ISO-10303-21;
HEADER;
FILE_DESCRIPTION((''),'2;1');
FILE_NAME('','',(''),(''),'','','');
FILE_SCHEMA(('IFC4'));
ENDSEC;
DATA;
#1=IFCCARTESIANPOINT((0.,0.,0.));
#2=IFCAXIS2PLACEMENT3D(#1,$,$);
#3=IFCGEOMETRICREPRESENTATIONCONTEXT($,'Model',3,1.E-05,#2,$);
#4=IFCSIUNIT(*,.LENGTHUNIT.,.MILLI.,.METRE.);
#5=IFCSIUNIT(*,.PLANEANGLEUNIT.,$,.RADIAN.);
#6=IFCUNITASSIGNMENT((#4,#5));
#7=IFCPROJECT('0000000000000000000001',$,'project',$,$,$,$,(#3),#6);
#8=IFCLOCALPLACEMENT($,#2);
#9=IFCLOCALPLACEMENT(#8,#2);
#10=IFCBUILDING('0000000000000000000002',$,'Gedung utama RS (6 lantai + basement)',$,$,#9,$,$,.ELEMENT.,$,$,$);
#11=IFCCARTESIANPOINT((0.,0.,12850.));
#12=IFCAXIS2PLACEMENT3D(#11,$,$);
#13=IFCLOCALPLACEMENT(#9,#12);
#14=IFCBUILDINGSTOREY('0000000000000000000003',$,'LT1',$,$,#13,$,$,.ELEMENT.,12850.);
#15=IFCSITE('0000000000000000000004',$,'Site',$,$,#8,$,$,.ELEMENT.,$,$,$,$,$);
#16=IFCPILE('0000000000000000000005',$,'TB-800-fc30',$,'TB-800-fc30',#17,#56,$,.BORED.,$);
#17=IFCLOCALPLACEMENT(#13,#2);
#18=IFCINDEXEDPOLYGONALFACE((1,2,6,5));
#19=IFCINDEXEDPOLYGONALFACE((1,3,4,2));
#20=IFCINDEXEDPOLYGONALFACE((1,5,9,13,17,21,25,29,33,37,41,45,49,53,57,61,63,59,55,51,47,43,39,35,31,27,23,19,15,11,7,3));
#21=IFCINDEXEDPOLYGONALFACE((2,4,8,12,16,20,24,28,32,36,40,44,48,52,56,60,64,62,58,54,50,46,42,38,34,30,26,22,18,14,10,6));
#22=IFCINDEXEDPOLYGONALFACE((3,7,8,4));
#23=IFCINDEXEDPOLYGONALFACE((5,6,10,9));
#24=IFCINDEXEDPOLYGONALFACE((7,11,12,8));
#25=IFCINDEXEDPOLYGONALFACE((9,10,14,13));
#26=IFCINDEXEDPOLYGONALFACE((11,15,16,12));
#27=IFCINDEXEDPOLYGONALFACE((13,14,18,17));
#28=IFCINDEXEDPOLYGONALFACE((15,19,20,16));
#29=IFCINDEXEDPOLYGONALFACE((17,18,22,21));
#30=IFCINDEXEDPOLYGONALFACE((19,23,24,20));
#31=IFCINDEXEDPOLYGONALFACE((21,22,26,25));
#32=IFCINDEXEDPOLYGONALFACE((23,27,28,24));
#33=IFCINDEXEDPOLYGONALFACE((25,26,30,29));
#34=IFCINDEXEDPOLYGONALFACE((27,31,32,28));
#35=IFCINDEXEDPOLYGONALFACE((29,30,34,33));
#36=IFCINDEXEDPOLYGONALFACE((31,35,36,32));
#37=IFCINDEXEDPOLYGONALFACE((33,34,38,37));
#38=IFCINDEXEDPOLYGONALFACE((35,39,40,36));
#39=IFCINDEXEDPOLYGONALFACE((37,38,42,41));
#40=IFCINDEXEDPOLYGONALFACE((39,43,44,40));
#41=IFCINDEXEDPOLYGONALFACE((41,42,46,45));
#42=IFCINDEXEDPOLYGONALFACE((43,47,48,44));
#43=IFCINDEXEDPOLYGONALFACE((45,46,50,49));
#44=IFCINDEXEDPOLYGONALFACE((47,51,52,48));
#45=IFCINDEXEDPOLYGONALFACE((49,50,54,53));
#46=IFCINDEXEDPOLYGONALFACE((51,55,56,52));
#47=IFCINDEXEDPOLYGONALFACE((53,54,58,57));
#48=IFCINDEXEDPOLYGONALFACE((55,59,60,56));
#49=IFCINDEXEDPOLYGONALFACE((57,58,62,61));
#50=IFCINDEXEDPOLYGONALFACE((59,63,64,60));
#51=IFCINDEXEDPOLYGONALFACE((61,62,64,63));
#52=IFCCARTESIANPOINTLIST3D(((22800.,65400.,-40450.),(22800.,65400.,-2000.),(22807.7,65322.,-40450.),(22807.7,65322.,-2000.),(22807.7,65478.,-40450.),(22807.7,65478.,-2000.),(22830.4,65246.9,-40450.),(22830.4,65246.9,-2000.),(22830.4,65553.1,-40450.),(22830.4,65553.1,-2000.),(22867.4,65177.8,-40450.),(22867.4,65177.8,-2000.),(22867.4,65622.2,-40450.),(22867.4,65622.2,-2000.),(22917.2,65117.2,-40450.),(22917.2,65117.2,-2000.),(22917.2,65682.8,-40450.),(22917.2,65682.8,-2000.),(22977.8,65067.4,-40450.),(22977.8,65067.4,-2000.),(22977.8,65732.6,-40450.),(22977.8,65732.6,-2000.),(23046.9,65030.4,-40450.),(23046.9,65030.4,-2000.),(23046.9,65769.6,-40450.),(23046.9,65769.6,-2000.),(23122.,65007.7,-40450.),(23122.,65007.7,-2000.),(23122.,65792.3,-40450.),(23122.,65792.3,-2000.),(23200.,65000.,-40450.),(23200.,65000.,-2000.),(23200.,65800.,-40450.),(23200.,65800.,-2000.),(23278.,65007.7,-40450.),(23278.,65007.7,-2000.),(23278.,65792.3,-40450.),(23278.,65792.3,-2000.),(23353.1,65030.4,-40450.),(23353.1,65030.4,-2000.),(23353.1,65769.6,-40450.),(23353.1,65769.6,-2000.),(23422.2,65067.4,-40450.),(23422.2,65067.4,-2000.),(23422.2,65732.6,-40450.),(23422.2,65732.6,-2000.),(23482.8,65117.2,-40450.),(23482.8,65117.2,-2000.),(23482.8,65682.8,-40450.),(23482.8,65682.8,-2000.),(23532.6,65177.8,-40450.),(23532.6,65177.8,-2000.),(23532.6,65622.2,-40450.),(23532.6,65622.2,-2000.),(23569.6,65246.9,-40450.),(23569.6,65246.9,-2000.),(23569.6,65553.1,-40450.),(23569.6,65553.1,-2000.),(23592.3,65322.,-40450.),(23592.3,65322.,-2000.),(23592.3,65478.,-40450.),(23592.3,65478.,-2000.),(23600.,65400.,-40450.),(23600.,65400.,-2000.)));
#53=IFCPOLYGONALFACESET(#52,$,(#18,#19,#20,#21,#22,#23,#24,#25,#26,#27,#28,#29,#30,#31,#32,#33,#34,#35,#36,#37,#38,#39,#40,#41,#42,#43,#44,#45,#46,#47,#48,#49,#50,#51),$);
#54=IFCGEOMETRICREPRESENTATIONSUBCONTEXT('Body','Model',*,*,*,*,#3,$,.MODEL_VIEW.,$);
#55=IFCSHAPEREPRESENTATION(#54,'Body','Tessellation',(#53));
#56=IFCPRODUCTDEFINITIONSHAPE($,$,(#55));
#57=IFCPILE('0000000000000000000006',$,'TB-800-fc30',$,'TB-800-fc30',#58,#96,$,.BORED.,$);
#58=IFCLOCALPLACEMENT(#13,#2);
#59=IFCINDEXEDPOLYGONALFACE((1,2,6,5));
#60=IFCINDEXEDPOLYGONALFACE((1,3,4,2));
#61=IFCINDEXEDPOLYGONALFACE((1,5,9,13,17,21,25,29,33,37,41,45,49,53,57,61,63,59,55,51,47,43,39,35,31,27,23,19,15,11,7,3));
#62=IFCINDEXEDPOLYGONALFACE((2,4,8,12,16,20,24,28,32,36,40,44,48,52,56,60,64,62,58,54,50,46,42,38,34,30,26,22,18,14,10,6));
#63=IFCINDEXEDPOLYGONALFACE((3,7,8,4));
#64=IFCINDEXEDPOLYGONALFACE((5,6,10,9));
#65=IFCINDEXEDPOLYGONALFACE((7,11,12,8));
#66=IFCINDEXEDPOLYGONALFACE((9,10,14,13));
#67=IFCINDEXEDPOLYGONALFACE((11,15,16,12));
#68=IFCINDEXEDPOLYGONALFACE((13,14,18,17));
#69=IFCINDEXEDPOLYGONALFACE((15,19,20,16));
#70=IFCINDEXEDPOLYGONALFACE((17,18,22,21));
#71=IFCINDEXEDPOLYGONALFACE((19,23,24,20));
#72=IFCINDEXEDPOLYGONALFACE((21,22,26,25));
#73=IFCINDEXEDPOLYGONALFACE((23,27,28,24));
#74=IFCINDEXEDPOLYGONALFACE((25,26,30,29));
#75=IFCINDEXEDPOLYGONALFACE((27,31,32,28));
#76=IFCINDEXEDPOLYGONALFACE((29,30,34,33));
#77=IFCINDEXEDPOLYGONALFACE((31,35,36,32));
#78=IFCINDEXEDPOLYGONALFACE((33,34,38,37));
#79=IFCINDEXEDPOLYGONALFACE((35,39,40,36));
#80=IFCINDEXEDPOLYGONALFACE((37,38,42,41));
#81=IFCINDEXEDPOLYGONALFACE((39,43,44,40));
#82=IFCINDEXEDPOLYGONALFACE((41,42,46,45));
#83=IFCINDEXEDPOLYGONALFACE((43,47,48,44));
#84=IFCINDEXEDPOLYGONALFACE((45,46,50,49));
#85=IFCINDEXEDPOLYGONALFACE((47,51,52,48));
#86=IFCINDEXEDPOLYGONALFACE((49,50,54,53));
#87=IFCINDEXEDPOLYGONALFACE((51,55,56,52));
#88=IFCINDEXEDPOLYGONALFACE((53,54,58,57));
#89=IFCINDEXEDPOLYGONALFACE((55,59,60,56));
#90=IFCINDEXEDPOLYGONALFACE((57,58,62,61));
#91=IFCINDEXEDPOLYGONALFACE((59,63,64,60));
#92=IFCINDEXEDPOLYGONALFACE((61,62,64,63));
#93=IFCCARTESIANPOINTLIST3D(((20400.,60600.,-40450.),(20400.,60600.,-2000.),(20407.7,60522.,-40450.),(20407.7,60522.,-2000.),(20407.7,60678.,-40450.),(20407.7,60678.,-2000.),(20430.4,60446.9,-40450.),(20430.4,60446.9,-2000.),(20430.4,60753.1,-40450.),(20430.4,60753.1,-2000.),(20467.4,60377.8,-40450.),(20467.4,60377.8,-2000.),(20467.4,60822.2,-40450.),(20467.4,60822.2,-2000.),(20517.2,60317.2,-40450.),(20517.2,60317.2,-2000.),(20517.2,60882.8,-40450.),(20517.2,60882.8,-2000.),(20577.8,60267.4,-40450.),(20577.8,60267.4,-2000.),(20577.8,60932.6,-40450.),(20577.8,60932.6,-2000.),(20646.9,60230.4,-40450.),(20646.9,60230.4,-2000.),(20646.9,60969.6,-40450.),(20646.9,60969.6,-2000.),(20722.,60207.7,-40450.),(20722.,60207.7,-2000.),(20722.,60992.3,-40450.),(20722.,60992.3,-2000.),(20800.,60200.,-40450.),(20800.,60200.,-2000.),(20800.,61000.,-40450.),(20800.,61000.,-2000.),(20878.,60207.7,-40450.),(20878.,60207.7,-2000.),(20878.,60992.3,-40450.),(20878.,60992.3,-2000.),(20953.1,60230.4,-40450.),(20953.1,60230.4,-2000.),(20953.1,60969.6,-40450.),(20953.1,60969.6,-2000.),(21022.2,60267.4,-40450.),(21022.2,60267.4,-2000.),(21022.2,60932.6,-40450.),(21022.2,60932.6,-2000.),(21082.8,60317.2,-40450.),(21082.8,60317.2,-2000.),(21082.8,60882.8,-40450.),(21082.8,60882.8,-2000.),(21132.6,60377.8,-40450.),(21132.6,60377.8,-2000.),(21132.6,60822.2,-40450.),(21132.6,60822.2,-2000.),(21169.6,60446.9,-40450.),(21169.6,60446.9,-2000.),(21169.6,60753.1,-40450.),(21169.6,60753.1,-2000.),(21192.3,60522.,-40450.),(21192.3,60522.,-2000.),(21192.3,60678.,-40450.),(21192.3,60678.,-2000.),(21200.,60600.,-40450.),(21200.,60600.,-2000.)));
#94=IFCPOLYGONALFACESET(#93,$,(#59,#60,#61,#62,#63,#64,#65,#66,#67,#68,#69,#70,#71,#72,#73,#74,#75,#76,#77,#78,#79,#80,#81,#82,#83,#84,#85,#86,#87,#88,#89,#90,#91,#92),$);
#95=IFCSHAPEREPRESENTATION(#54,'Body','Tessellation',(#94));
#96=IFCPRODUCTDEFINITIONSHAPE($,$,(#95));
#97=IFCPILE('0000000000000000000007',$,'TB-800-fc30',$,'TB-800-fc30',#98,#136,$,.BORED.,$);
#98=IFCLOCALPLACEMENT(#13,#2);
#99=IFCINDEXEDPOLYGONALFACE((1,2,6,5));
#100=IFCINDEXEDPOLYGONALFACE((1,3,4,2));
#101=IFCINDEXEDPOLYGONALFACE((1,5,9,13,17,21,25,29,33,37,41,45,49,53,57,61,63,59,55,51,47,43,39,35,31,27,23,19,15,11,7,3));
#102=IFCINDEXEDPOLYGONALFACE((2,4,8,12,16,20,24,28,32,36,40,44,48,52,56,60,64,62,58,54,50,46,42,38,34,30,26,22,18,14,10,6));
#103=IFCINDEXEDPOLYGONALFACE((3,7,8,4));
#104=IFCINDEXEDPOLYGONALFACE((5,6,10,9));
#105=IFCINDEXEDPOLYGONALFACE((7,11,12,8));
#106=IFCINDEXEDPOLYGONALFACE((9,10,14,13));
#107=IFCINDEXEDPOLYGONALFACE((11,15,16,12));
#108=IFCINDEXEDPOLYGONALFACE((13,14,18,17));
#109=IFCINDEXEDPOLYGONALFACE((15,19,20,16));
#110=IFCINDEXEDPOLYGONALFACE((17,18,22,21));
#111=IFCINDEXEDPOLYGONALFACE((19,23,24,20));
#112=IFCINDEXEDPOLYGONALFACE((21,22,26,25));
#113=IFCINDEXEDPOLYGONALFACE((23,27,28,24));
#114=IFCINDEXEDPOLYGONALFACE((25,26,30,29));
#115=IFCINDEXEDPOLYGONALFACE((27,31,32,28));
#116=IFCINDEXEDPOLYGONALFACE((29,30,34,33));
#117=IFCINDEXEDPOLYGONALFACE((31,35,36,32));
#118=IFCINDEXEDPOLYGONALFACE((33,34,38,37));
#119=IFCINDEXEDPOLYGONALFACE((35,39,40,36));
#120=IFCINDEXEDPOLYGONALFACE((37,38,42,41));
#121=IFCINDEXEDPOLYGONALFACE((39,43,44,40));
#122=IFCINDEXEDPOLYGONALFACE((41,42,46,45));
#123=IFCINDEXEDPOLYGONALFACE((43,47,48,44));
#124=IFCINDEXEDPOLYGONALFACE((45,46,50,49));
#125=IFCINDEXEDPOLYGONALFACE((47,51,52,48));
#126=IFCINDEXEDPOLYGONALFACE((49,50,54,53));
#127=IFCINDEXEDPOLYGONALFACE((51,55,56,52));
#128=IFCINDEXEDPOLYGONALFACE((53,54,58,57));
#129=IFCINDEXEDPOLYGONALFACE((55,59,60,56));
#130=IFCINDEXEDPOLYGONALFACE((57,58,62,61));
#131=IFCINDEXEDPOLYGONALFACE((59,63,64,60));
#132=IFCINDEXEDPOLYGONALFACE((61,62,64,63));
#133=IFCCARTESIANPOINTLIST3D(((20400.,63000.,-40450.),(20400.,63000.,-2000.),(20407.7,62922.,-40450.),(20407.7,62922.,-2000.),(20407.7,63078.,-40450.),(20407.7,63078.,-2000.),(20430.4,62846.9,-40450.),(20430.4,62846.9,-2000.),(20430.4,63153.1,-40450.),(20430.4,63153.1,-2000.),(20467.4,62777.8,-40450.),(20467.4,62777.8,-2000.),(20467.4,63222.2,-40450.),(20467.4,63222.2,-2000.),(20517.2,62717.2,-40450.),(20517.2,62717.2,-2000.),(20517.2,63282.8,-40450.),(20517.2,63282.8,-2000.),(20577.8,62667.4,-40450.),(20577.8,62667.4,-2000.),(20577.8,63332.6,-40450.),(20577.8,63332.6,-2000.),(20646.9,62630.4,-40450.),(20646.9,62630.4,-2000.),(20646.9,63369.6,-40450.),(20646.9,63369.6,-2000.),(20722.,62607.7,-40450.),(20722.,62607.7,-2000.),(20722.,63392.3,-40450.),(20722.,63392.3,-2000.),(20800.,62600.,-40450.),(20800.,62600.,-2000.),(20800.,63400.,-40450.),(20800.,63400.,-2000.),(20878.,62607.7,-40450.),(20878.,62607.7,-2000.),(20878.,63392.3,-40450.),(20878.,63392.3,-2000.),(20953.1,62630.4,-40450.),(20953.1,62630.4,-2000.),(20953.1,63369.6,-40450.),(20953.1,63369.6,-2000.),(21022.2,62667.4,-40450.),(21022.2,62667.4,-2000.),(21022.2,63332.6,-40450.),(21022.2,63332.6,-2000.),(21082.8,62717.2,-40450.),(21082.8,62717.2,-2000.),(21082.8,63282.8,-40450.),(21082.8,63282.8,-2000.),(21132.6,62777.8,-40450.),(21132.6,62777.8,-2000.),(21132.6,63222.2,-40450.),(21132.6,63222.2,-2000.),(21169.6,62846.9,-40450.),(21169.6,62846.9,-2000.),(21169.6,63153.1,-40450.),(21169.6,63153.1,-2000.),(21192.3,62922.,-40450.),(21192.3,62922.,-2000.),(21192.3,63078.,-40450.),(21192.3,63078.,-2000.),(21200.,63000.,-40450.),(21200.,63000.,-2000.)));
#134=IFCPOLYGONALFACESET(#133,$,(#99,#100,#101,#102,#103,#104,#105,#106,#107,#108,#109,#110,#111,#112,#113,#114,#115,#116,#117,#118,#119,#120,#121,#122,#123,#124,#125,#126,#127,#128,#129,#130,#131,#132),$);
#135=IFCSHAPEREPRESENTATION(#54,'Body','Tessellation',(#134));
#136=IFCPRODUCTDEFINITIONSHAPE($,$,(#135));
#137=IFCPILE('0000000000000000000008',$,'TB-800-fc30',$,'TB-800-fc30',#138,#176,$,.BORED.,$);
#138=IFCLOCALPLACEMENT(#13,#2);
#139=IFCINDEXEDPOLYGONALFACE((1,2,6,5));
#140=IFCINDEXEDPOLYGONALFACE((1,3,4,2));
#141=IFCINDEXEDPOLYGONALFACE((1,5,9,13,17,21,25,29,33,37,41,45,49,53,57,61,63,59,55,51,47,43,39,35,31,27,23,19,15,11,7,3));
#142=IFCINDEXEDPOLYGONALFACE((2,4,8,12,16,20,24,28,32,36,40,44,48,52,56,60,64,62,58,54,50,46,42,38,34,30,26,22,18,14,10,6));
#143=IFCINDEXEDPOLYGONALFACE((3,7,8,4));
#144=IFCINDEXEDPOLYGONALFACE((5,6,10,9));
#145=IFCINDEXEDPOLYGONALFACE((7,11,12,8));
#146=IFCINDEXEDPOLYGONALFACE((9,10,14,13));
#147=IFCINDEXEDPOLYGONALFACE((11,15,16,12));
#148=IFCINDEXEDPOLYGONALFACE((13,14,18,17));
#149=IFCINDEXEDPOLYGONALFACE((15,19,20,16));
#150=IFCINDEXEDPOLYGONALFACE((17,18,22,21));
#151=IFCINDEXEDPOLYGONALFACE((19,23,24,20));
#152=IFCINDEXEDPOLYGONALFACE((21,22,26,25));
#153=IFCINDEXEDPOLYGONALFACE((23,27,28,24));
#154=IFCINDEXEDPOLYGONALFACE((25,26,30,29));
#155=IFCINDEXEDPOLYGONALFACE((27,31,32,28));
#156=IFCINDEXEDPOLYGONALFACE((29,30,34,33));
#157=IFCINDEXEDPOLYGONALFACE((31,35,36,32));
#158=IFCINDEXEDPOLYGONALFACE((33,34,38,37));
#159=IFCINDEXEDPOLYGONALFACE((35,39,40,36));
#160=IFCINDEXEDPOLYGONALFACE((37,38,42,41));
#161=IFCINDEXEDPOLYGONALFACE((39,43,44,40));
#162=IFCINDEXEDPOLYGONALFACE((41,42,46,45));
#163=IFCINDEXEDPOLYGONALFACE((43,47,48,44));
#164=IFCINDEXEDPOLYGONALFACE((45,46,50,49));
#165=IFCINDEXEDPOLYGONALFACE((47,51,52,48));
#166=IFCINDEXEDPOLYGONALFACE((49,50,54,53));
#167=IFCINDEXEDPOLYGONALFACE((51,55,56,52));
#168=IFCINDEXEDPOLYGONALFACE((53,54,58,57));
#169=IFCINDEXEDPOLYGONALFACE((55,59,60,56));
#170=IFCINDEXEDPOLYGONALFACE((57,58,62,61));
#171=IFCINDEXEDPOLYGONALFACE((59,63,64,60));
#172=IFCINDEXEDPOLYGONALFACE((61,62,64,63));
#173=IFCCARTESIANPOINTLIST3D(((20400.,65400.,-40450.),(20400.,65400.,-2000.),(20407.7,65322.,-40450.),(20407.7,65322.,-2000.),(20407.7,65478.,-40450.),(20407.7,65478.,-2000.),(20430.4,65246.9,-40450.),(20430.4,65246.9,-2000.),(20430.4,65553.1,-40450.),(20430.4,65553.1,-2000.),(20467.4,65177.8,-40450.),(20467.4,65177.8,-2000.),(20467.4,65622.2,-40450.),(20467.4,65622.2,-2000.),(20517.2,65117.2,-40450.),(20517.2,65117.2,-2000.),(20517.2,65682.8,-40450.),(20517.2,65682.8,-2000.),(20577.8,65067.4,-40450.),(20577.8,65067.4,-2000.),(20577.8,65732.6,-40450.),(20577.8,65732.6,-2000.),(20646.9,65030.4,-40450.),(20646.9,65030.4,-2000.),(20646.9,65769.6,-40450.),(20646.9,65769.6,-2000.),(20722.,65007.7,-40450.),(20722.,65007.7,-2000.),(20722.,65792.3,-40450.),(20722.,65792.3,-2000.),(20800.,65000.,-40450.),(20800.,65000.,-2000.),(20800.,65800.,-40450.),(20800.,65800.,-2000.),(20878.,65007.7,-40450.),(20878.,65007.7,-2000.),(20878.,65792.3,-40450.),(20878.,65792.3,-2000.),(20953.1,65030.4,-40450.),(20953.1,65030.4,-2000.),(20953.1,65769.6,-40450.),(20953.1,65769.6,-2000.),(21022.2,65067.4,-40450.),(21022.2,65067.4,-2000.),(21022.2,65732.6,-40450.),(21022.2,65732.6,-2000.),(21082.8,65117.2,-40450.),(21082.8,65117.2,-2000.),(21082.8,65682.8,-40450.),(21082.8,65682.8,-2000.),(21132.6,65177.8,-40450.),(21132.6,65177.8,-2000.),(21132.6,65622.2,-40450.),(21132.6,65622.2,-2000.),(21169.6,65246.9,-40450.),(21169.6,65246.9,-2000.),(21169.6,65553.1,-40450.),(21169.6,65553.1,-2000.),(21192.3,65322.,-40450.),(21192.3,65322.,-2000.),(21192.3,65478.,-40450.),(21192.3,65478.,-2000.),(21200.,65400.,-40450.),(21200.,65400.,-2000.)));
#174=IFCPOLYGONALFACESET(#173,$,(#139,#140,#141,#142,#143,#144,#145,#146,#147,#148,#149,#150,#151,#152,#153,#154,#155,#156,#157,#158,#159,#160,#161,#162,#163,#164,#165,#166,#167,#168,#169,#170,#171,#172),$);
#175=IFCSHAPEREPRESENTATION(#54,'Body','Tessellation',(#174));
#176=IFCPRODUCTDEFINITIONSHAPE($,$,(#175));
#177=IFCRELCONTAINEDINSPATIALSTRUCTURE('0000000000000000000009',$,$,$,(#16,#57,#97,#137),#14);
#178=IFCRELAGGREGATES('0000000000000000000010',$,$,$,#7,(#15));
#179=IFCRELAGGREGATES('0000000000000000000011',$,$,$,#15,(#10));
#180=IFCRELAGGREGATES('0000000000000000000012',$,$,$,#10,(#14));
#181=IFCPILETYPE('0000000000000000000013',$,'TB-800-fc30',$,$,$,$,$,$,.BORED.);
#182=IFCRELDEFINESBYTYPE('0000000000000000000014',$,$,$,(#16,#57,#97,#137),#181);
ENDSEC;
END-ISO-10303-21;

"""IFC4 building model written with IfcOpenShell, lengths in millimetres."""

from ifc_helpers import new_model, si_unit, frame, origin, origin_2d, place, context, subcontext, project, spatial, circle, extrude, material_profile, profile_set, profile_usage, type_object, element, save


model = new_model("IFC4")

# Units and contexts
model_context = context("Model", 3, precision=1e-05, world=origin())
body_context = subcontext(model_context, "Body", "Model", "MODEL_VIEW")
ifc_project = project(units=[si_unit("LENGTHUNIT", "METRE", prefix="MILLI"), si_unit("PLANEANGLEUNIT", "RADIAN")], contexts=[model_context])

# Site, building, storey
site_placement = place(None, origin())
site = spatial("IfcSite", under=ifc_project, at=site_placement, Name="Site", CompositionType="ELEMENT")
building_placement = place(site_placement, origin())
building = spatial("IfcBuilding", under=site, at=building_placement, Name="Gedung utama RS (6 lantai + basement)", CompositionType="ELEMENT")
storey_placement = place(building_placement, frame((0.0, 0.0, 12850.0)))
storey = spatial("IfcBuildingStorey", under=building, at=storey_placement, Name="LT1", CompositionType="ELEMENT", Elevation=12850.0)

# Piles
ifc_material_profile = material_profile(None, circle(Radius=400.0, at=origin_2d()), Name="TB-800-fc30")
ifc_profile_set = profile_set([ifc_material_profile], Name="TB-800-fc30")
ifc_profile_usage = profile_usage(ifc_profile_set, cardinal=5)
pile_type = type_object("IfcPileType", Name="TB-800-fc30", PredefinedType="BORED", material=ifc_profile_set)
for number, where, z_axis, x_axis, name in (
    (1, (23200.0, 65400.0, -40450.0), (0.0, 0.0, 1.0), (1.0, 0.0, 0.0), "TB-800-fc30"),
    (2, (20800.0, 60600.0, -40450.0), (0.0, 0.0, 1.0), (1.0, 0.0, 0.0), "TB-800-fc30"),
    (3, (20800.0, 63000.0, -40450.0), (0.0, 0.0, 1.0), (1.0, 0.0, 0.0), "TB-800-fc30"),
    (4, (20800.0, 65400.0, -40450.0), (0.0, 0.0, 1.0), (1.0, 0.0, 0.0), "TB-800-fc30"),
):
    element("IfcPile", number, at=place(storey_placement, frame(where, z_axis=z_axis, x_axis=x_axis)), inside=storey, type_object=pile_type, material=ifc_profile_usage, Name=name, ObjectType="TB-800-fc30", PredefinedType="BORED", context=body_context, shape_type="SweptSolid", body=[
        extrude(circle(Radius=400.0, at=origin_2d()), origin(), (0.0, 0.0, 1.0), 38450.0),
    ])

save(model, "model.ifc")
